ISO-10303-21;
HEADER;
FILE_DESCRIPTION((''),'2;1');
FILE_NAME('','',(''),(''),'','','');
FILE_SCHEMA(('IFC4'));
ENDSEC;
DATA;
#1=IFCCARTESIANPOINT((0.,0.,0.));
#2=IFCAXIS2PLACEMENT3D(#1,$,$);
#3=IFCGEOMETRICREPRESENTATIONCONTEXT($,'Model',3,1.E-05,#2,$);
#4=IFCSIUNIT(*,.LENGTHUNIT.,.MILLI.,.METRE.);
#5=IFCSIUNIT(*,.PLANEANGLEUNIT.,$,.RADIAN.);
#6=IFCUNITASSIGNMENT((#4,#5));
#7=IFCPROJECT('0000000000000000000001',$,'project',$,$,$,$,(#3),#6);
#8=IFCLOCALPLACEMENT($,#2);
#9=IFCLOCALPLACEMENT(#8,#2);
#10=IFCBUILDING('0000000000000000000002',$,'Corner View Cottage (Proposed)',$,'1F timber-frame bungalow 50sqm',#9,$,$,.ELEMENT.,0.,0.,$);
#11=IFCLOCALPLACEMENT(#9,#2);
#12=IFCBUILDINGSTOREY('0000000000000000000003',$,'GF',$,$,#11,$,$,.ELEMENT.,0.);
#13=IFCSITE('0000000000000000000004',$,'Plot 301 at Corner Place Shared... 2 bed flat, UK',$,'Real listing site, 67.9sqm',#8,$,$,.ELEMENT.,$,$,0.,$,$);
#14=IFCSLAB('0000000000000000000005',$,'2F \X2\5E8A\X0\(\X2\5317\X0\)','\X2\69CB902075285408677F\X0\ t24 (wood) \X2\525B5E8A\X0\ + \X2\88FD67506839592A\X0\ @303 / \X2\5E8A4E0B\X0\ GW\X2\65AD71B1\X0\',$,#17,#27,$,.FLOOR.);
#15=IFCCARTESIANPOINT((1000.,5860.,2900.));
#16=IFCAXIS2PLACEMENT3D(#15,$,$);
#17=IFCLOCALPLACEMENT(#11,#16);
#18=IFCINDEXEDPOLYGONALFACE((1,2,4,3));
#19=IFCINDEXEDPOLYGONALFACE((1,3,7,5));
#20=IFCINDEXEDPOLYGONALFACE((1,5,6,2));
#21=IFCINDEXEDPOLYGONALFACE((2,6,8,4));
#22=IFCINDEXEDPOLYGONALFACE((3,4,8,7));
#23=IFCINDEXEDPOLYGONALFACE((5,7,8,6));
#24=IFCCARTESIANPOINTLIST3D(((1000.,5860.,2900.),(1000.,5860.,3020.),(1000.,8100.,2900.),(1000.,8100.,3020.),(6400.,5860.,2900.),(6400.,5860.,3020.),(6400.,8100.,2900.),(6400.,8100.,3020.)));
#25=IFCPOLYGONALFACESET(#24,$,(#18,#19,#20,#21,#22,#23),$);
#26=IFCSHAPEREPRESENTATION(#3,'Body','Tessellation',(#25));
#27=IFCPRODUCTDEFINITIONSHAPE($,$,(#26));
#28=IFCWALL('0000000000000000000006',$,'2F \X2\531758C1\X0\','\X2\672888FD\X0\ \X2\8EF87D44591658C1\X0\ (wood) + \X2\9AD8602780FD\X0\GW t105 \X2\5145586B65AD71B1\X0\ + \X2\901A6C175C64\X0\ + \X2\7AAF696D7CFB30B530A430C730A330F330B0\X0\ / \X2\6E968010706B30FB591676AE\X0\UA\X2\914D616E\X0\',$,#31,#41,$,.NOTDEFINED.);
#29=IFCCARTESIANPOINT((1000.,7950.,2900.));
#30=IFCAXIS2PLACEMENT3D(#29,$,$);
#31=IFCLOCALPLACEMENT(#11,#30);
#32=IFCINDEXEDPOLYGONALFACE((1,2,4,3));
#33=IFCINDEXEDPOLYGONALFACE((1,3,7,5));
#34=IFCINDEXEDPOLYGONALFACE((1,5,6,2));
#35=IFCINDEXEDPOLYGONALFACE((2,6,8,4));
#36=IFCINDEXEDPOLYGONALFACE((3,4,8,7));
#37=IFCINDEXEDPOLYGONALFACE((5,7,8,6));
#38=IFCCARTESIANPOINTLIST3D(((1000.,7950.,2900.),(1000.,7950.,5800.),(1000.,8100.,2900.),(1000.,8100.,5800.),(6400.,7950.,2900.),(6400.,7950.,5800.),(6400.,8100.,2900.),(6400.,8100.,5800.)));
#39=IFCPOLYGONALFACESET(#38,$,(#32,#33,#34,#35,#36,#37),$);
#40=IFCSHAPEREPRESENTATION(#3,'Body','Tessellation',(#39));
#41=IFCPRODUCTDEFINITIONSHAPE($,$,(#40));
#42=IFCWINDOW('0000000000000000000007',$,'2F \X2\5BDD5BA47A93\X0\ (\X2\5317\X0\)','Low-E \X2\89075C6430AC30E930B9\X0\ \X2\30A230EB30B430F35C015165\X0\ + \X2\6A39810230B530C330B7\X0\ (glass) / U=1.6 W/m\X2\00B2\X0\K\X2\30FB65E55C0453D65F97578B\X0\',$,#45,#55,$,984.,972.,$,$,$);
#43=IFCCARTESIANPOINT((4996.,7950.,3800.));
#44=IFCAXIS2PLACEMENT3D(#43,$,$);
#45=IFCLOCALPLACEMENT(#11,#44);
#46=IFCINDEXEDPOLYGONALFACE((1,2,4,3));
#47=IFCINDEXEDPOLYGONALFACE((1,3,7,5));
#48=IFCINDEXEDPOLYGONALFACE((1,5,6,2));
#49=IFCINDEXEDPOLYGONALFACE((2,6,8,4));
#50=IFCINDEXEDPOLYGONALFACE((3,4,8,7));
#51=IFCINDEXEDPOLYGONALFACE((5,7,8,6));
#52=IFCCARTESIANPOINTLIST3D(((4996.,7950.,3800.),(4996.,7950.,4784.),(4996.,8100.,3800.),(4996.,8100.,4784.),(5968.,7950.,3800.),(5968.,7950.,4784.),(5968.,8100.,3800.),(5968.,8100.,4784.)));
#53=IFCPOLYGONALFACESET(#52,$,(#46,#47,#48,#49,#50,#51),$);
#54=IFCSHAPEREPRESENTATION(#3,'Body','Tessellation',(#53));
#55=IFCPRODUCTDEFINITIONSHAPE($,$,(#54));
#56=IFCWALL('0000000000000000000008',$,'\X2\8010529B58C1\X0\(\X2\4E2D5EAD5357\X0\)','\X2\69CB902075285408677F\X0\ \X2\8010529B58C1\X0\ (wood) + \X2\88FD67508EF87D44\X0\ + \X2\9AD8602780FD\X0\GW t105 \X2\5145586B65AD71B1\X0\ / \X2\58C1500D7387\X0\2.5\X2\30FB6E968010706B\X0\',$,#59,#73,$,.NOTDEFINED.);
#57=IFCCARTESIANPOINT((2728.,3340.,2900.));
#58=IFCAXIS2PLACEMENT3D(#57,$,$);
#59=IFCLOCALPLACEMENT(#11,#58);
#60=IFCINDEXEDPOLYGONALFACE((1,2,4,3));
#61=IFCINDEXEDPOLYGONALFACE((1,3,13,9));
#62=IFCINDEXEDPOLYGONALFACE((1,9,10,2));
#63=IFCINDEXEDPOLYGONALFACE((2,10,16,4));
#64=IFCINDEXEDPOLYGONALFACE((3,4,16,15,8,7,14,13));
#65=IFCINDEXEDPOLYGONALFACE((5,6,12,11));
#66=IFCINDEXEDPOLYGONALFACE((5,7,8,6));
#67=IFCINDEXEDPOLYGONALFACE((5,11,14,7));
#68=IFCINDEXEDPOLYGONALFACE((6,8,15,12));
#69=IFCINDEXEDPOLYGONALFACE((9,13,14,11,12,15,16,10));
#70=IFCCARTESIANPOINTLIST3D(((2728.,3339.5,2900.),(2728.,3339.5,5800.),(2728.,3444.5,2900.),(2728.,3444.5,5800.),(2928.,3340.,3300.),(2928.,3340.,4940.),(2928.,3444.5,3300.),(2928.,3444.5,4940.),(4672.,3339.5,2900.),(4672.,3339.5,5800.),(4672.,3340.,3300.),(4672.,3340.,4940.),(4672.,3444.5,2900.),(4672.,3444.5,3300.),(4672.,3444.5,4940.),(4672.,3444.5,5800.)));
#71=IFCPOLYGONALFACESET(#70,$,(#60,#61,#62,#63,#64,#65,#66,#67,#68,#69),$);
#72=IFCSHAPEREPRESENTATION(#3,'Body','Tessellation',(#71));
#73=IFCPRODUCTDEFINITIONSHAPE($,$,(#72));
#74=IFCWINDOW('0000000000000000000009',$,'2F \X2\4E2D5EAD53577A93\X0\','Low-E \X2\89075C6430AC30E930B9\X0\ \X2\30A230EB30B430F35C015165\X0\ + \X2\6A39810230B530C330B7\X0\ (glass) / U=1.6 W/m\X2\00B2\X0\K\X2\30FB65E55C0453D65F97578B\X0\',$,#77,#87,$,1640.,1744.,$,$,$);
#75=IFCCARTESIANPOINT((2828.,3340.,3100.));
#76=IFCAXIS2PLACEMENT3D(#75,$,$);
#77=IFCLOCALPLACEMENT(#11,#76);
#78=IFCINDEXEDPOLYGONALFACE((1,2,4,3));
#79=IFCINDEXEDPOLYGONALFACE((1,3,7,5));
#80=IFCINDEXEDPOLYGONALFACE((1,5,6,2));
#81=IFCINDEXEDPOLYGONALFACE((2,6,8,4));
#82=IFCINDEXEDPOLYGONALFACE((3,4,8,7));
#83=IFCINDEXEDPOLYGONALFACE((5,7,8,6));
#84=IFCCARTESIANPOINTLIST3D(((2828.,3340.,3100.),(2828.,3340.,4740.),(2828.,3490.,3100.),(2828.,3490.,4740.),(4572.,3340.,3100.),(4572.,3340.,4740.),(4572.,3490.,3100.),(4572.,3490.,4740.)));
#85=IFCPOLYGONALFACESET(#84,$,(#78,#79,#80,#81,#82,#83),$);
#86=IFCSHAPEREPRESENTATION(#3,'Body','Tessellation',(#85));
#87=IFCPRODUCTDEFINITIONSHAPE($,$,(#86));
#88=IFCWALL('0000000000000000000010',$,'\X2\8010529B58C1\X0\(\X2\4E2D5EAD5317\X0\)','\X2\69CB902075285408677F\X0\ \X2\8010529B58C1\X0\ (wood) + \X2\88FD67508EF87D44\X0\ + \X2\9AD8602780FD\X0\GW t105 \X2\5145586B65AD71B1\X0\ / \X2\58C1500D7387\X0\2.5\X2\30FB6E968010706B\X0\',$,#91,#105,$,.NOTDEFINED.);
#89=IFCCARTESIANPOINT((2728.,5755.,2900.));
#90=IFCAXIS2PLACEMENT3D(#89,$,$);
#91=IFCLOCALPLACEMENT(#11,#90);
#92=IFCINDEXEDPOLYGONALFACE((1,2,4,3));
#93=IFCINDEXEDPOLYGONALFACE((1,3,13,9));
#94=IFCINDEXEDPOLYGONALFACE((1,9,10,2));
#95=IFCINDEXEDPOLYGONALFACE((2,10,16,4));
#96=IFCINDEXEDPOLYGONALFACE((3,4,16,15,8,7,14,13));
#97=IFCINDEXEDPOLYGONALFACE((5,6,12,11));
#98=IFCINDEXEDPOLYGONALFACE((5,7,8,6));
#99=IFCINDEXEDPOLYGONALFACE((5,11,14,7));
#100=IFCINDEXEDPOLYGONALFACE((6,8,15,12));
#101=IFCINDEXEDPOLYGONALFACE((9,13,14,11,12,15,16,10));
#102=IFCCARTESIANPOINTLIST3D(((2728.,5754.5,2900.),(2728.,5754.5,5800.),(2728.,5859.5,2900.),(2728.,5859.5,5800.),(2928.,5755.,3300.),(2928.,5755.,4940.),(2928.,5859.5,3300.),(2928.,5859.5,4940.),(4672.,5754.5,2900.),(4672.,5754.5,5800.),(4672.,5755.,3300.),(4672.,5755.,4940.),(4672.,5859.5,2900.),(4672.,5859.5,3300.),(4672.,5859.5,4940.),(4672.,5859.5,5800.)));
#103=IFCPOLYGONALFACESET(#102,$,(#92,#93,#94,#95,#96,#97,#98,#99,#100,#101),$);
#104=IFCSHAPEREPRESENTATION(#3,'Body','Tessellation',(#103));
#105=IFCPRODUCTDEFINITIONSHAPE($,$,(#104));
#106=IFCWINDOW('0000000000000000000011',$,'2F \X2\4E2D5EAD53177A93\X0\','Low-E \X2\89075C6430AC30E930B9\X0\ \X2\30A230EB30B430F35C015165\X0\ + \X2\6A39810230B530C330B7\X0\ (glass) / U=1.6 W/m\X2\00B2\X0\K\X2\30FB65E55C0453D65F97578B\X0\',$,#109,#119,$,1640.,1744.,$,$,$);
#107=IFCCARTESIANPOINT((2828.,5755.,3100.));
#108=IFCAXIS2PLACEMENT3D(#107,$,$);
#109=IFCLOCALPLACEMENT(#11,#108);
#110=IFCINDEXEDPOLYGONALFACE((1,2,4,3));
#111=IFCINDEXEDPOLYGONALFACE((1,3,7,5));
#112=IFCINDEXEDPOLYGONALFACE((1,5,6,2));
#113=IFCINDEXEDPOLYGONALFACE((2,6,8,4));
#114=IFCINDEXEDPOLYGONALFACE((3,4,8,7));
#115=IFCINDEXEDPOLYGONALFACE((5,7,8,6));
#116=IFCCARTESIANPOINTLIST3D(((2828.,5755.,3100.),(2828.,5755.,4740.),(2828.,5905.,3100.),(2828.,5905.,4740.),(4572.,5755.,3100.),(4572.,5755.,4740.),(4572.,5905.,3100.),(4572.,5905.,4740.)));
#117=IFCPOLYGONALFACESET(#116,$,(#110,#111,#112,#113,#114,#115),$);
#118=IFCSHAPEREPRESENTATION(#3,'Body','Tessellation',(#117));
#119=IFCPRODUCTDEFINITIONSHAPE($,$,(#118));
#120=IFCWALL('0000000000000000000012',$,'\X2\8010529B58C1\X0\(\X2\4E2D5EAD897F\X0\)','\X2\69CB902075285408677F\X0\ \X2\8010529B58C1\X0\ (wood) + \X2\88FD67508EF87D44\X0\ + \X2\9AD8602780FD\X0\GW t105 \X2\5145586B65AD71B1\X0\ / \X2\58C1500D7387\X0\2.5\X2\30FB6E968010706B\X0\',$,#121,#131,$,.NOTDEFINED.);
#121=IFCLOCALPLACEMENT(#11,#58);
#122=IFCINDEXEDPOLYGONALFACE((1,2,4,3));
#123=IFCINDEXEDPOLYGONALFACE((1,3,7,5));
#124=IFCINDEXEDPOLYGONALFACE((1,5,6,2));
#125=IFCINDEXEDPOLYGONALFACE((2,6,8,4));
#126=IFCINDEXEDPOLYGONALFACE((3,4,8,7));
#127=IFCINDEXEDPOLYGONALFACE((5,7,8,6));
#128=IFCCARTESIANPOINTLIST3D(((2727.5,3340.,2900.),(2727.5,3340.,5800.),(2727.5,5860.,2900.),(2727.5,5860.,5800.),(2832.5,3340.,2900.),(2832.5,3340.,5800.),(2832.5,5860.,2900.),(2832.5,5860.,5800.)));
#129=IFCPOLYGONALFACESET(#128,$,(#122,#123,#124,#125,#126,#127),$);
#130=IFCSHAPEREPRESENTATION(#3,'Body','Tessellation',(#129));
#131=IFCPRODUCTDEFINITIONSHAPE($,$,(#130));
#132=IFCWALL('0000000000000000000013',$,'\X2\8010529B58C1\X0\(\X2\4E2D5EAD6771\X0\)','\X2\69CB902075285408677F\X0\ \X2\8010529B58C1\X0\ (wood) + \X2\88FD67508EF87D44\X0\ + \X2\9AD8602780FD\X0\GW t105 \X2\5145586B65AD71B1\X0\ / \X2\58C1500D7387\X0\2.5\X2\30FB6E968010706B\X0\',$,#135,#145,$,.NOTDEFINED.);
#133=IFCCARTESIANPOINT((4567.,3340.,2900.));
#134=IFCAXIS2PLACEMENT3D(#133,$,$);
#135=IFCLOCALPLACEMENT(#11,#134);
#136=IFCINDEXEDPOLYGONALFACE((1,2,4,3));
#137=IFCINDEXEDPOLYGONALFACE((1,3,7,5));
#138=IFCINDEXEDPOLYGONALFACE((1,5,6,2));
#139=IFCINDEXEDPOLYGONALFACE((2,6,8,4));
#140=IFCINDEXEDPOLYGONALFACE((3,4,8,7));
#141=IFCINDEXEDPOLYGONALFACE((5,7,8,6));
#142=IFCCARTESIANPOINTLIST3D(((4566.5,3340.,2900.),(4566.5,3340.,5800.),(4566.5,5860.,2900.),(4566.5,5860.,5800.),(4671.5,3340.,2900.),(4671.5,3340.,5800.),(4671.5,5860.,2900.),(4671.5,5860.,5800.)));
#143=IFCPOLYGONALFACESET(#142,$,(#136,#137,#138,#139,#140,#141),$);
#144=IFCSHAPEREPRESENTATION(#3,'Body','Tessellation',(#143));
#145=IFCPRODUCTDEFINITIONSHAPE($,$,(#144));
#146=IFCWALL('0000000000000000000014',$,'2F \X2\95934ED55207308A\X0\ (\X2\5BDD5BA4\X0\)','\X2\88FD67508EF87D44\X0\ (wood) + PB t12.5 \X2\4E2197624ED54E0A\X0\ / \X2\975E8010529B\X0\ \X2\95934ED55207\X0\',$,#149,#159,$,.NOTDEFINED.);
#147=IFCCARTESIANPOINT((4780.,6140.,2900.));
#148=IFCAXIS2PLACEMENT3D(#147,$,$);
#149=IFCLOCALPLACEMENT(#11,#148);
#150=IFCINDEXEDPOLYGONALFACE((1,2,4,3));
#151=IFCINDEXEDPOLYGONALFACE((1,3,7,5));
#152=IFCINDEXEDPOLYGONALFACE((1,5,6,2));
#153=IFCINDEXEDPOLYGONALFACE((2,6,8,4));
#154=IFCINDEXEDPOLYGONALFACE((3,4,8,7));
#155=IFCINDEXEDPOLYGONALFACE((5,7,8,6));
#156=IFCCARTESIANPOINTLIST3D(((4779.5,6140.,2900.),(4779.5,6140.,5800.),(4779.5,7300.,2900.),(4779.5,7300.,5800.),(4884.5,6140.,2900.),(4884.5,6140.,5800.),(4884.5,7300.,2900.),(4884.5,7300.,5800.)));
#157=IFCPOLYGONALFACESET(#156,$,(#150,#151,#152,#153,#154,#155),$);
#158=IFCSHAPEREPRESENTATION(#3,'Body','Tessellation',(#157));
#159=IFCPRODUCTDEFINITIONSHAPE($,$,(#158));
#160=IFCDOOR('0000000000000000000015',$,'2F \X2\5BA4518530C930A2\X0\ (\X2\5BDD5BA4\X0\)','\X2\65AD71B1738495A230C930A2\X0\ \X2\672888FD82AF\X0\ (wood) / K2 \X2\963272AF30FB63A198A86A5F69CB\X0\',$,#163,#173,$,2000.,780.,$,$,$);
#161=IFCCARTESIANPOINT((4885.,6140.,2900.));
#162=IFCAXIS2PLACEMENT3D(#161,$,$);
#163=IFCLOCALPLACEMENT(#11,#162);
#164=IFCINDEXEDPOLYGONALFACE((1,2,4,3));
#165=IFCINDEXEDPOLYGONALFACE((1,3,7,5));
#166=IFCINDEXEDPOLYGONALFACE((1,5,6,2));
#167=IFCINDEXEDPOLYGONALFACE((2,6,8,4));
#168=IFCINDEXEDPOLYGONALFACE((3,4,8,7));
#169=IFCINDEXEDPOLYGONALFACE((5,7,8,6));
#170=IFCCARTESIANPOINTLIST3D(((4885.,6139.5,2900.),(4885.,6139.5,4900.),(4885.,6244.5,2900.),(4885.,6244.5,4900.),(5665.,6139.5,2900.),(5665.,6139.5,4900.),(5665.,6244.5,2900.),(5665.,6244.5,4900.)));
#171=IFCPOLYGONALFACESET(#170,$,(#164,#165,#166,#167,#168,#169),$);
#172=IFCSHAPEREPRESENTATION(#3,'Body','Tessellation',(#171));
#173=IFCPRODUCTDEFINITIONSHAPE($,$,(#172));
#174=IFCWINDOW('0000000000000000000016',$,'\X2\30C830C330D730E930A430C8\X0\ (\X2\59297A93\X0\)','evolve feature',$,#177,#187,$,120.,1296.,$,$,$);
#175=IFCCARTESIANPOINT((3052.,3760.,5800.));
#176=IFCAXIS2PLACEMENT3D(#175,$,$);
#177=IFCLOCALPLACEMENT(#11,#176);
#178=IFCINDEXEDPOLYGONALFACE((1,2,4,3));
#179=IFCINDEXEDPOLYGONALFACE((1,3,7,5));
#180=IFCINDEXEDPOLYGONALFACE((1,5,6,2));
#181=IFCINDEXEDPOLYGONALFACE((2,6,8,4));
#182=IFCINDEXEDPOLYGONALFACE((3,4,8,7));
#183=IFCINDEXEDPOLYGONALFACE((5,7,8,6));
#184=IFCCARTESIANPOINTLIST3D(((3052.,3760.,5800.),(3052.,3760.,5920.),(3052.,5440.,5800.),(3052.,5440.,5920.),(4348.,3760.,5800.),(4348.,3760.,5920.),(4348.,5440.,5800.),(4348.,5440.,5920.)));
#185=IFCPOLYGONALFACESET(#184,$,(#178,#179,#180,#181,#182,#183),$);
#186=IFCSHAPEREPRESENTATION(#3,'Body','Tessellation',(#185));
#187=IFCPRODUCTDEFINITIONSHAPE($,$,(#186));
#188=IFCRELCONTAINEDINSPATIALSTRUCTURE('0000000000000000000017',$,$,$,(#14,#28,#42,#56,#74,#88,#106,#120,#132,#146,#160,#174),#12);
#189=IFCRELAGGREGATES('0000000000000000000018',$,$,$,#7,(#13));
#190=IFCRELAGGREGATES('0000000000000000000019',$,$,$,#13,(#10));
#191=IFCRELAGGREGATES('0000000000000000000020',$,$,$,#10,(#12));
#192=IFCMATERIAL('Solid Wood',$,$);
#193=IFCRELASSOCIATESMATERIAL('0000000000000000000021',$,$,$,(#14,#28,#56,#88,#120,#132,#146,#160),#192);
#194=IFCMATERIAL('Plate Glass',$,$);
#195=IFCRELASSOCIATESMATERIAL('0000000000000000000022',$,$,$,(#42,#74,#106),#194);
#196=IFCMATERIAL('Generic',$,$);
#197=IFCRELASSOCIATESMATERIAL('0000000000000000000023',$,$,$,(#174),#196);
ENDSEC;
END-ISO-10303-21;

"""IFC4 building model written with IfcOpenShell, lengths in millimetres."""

from ifc_helpers import new_model, si_unit, frame, frame_2d, origin, place, context, project, spatial, rectangle, extrude, material, element, fill, save


model = new_model("IFC4")

# Units and contexts
model_context = context("Model", 3, precision=1e-05, world=origin())
ifc_project = project(units=[si_unit("LENGTHUNIT", "METRE", prefix="MILLI"), si_unit("PLANEANGLEUNIT", "RADIAN")], contexts=[model_context])

# Site, building, storey
site_placement = place(None, origin())
site = spatial("IfcSite", under=ifc_project, at=site_placement, Name="Plot 301 at Corner Place Shared... 2 bed flat, UK", ObjectType="Real listing site, 67.9sqm", CompositionType="ELEMENT", RefElevation=0.0)
building_placement = place(site_placement, origin())
building = spatial("IfcBuilding", under=site, at=building_placement, Name="Corner View Cottage (Proposed)", ObjectType="1F timber-frame bungalow 50sqm", CompositionType="ELEMENT", ElevationOfRefHeight=0.0, ElevationOfTerrain=0.0)
storey_placement = place(building_placement, origin())
storey = spatial("IfcBuildingStorey", under=building, at=storey_placement, Name="GF", CompositionType="ELEMENT", Elevation=0.0)

# Slab
ifc_material_1 = material(Name="Solid Wood")
slab_placement = place(storey_placement, frame((1000.0, 5860.0, 2900.0)))
element("IfcSlab", 1, at=slab_placement, inside=storey, material=ifc_material_1, Name="2F 床(北)", Description="構造用合板 t24 (wood) 剛床 + 製材根太 @303 / 床下 GW断熱", PredefinedType="FLOOR", context=model_context, shape_type="SweptSolid", body=[
    extrude(rectangle(XDim=5400.0, YDim=2240.0, at=frame_2d((2700.0, 1120.0))), frame((1000.0, 5860.0, 2900.0)), (0.0, 0.0, 1.0), 120.0),
])

# Walls, openings, windows
wall_1_placement = place(storey_placement, frame((1000.0, 7950.0, 2900.0)))
wall_1 = element("IfcWall", 2, at=wall_1_placement, inside=storey, material=ifc_material_1, Name="2F 北壁", Description="木製 軸組外壁 (wood) + 高性能GW t105 充填断熱 + 通気層 + 窯業系サイディング / 準耐火・外皮UA配慮", PredefinedType="NOTDEFINED", context=model_context, shape_type="SweptSolid", body=[
    extrude(rectangle(XDim=5400.0, YDim=150.0, at=frame_2d((2700.0, 75.0))), frame((1000.0, 7950.0, 2900.0)), (0.0, 0.0, 1.0), 2900.0),
])
opening_1_placement = place(storey_placement, frame((4996.0, 7950.0, 3800.0)))
opening_1 = element("IfcOpeningElement", 3, at=opening_1_placement, cuts=wall_1, PredefinedType="NOTDEFINED", context=model_context, shape_type="SweptSolid", body=[
    extrude(rectangle(XDim=972.0, YDim=150.0, at=frame_2d((486.0, 75.0))), frame((4996.0, 7950.0, 3800.0)), (0.0, 0.0, 1.0), 984.0),
])
ifc_material_2 = material(Name="Plate Glass")
window_1_placement = place(storey_placement, frame((4996.0, 7950.0, 3800.0)))
window_1 = element("IfcWindow", 4, at=window_1_placement, inside=storey, material=ifc_material_2, Name="2F 寝室窓 (北)", Description="Low-E 複層ガラス アルゴン封入 + 樹脂サッシ (glass) / U=1.6 W/m²K・日射取得型", OverallHeight=984.0, OverallWidth=972.0, context=model_context, shape_type="SweptSolid", body=[
    extrude(rectangle(XDim=972.0, YDim=150.0, at=frame_2d((486.0, 75.0))), frame((4996.0, 7950.0, 3800.0)), (0.0, 0.0, 1.0), 984.0),
])
fill(opening_1, window_1)
wall_2_placement = place(storey_placement, frame((2728.0, 3340.0, 2900.0)))
wall_2 = element("IfcWall", 5, at=wall_2_placement, inside=storey, material=ifc_material_1, Name="耐力壁(中庭南)", Description="構造用合板 耐力壁 (wood) + 製材軸組 + 高性能GW t105 充填断熱 / 壁倍率2.5・準耐火", PredefinedType="NOTDEFINED", context=model_context, shape_type="SweptSolid", body=[
    extrude(rectangle(XDim=1944.0, YDim=105.0, at=frame_2d((972.0, 52.0))), frame((2728.0, 3340.0, 2900.0)), (0.0, 0.0, 1.0), 2900.0),
])
opening_2_placement = place(storey_placement, frame((2828.0, 3340.0, 3100.0)))
opening_2 = element("IfcOpeningElement", 6, at=opening_2_placement, cuts=wall_2, PredefinedType="NOTDEFINED", context=model_context, shape_type="SweptSolid", body=[
    extrude(rectangle(XDim=1744.0, YDim=150.0, at=frame_2d((872.0, 75.0))), frame((2828.0, 3340.0, 3100.0)), (0.0, 0.0, 1.0), 1640.0),
])
window_2_placement = place(storey_placement, frame((2828.0, 3340.0, 3100.0)))
window_2 = element("IfcWindow", 7, at=window_2_placement, inside=storey, material=ifc_material_2, Name="2F 中庭南窓", Description="Low-E 複層ガラス アルゴン封入 + 樹脂サッシ (glass) / U=1.6 W/m²K・日射取得型", OverallHeight=1640.0, OverallWidth=1744.0, context=model_context, shape_type="SweptSolid", body=[
    extrude(rectangle(XDim=1744.0, YDim=150.0, at=frame_2d((872.0, 75.0))), frame((2828.0, 3340.0, 3100.0)), (0.0, 0.0, 1.0), 1640.0),
])
fill(opening_2, window_2)
wall_3_placement = place(storey_placement, frame((2728.0, 5755.0, 2900.0)))
wall_3 = element("IfcWall", 8, at=wall_3_placement, inside=storey, material=ifc_material_1, Name="耐力壁(中庭北)", Description="構造用合板 耐力壁 (wood) + 製材軸組 + 高性能GW t105 充填断熱 / 壁倍率2.5・準耐火", PredefinedType="NOTDEFINED", context=model_context, shape_type="SweptSolid", body=[
    extrude(rectangle(XDim=1944.0, YDim=105.0, at=frame_2d((972.0, 52.0))), frame((2728.0, 5755.0, 2900.0)), (0.0, 0.0, 1.0), 2900.0),
])
opening_3_placement = place(storey_placement, frame((2828.0, 5755.0, 3100.0)))
opening_3 = element("IfcOpeningElement", 9, at=opening_3_placement, cuts=wall_3, PredefinedType="NOTDEFINED", context=model_context, shape_type="SweptSolid", body=[
    extrude(rectangle(XDim=1744.0, YDim=150.0, at=frame_2d((872.0, 75.0))), frame((2828.0, 5755.0, 3100.0)), (0.0, 0.0, 1.0), 1640.0),
])
window_3_placement = place(storey_placement, frame((2828.0, 5755.0, 3100.0)))
window_3 = element("IfcWindow", 10, at=window_3_placement, inside=storey, material=ifc_material_2, Name="2F 中庭北窓", Description="Low-E 複層ガラス アルゴン封入 + 樹脂サッシ (glass) / U=1.6 W/m²K・日射取得型", OverallHeight=1640.0, OverallWidth=1744.0, context=model_context, shape_type="SweptSolid", body=[
    extrude(rectangle(XDim=1744.0, YDim=150.0, at=frame_2d((872.0, 75.0))), frame((2828.0, 5755.0, 3100.0)), (0.0, 0.0, 1.0), 1640.0),
])
fill(opening_3, window_3)

# Walls
wall_4_placement = place(storey_placement, frame((2728.0, 3340.0, 2900.0)))
element("IfcWall", 11, at=wall_4_placement, inside=storey, material=ifc_material_1, Name="耐力壁(中庭西)", Description="構造用合板 耐力壁 (wood) + 製材軸組 + 高性能GW t105 充填断熱 / 壁倍率2.5・準耐火", PredefinedType="NOTDEFINED", context=model_context, shape_type="SweptSolid", body=[
    extrude(rectangle(XDim=105.0, YDim=2520.0, at=frame_2d((52.0, 1260.0))), frame((2728.0, 3340.0, 2900.0)), (0.0, 0.0, 1.0), 2900.0),
])
wall_5_placement = place(storey_placement, frame((4567.0, 3340.0, 2900.0)))
element("IfcWall", 12, at=wall_5_placement, inside=storey, material=ifc_material_1, Name="耐力壁(中庭東)", Description="構造用合板 耐力壁 (wood) + 製材軸組 + 高性能GW t105 充填断熱 / 壁倍率2.5・準耐火", PredefinedType="NOTDEFINED", context=model_context, shape_type="SweptSolid", body=[
    extrude(rectangle(XDim=105.0, YDim=2520.0, at=frame_2d((52.0, 1260.0))), frame((4567.0, 3340.0, 2900.0)), (0.0, 0.0, 1.0), 2900.0),
])
wall_6_placement = place(storey_placement, frame((4780.0, 6140.0, 2900.0)))
element("IfcWall", 13, at=wall_6_placement, inside=storey, material=ifc_material_1, Name="2F 間仕切り (寝室)", Description="製材軸組 (wood) + PB t12.5 両面仕上 / 非耐力 間仕切", PredefinedType="NOTDEFINED", context=model_context, shape_type="SweptSolid", body=[
    extrude(rectangle(XDim=105.0, YDim=1160.0, at=frame_2d((52.0, 580.0))), frame((4780.0, 6140.0, 2900.0)), (0.0, 0.0, 1.0), 2900.0),
])

# Door
door_placement = place(storey_placement, frame((4885.0, 6140.0, 2900.0)))
element("IfcDoor", 14, at=door_placement, inside=storey, material=ifc_material_1, Name="2F 室内ドア (寝室)", Description="断熱玄関ドア 木製芯 (wood) / K2 防犯・採風機構", OverallHeight=2000.0, OverallWidth=780.0, context=model_context, shape_type="SweptSolid", body=[
    extrude(rectangle(XDim=780.0, YDim=105.0, at=frame_2d((390.0, 52.0))), frame((4885.0, 6140.0, 2900.0)), (0.0, 0.0, 1.0), 2000.0),
])

# Window
ifc_material_3 = material(Name="Generic")
window_4_placement = place(storey_placement, frame((3052.0, 3760.0, 5800.0)))
element("IfcWindow", 15, at=window_4_placement, inside=storey, material=ifc_material_3, Name="トップライト (天窓)", Description="evolve feature", OverallHeight=120.0, OverallWidth=1296.0, context=model_context, shape_type="SweptSolid", body=[
    extrude(rectangle(XDim=1296.0, YDim=1680.0, at=frame_2d((648.0, 840.0))), frame((3052.0, 3760.0, 5800.0)), (0.0, 0.0, 1.0), 120.0),
])

save(model, "model.ifc")
